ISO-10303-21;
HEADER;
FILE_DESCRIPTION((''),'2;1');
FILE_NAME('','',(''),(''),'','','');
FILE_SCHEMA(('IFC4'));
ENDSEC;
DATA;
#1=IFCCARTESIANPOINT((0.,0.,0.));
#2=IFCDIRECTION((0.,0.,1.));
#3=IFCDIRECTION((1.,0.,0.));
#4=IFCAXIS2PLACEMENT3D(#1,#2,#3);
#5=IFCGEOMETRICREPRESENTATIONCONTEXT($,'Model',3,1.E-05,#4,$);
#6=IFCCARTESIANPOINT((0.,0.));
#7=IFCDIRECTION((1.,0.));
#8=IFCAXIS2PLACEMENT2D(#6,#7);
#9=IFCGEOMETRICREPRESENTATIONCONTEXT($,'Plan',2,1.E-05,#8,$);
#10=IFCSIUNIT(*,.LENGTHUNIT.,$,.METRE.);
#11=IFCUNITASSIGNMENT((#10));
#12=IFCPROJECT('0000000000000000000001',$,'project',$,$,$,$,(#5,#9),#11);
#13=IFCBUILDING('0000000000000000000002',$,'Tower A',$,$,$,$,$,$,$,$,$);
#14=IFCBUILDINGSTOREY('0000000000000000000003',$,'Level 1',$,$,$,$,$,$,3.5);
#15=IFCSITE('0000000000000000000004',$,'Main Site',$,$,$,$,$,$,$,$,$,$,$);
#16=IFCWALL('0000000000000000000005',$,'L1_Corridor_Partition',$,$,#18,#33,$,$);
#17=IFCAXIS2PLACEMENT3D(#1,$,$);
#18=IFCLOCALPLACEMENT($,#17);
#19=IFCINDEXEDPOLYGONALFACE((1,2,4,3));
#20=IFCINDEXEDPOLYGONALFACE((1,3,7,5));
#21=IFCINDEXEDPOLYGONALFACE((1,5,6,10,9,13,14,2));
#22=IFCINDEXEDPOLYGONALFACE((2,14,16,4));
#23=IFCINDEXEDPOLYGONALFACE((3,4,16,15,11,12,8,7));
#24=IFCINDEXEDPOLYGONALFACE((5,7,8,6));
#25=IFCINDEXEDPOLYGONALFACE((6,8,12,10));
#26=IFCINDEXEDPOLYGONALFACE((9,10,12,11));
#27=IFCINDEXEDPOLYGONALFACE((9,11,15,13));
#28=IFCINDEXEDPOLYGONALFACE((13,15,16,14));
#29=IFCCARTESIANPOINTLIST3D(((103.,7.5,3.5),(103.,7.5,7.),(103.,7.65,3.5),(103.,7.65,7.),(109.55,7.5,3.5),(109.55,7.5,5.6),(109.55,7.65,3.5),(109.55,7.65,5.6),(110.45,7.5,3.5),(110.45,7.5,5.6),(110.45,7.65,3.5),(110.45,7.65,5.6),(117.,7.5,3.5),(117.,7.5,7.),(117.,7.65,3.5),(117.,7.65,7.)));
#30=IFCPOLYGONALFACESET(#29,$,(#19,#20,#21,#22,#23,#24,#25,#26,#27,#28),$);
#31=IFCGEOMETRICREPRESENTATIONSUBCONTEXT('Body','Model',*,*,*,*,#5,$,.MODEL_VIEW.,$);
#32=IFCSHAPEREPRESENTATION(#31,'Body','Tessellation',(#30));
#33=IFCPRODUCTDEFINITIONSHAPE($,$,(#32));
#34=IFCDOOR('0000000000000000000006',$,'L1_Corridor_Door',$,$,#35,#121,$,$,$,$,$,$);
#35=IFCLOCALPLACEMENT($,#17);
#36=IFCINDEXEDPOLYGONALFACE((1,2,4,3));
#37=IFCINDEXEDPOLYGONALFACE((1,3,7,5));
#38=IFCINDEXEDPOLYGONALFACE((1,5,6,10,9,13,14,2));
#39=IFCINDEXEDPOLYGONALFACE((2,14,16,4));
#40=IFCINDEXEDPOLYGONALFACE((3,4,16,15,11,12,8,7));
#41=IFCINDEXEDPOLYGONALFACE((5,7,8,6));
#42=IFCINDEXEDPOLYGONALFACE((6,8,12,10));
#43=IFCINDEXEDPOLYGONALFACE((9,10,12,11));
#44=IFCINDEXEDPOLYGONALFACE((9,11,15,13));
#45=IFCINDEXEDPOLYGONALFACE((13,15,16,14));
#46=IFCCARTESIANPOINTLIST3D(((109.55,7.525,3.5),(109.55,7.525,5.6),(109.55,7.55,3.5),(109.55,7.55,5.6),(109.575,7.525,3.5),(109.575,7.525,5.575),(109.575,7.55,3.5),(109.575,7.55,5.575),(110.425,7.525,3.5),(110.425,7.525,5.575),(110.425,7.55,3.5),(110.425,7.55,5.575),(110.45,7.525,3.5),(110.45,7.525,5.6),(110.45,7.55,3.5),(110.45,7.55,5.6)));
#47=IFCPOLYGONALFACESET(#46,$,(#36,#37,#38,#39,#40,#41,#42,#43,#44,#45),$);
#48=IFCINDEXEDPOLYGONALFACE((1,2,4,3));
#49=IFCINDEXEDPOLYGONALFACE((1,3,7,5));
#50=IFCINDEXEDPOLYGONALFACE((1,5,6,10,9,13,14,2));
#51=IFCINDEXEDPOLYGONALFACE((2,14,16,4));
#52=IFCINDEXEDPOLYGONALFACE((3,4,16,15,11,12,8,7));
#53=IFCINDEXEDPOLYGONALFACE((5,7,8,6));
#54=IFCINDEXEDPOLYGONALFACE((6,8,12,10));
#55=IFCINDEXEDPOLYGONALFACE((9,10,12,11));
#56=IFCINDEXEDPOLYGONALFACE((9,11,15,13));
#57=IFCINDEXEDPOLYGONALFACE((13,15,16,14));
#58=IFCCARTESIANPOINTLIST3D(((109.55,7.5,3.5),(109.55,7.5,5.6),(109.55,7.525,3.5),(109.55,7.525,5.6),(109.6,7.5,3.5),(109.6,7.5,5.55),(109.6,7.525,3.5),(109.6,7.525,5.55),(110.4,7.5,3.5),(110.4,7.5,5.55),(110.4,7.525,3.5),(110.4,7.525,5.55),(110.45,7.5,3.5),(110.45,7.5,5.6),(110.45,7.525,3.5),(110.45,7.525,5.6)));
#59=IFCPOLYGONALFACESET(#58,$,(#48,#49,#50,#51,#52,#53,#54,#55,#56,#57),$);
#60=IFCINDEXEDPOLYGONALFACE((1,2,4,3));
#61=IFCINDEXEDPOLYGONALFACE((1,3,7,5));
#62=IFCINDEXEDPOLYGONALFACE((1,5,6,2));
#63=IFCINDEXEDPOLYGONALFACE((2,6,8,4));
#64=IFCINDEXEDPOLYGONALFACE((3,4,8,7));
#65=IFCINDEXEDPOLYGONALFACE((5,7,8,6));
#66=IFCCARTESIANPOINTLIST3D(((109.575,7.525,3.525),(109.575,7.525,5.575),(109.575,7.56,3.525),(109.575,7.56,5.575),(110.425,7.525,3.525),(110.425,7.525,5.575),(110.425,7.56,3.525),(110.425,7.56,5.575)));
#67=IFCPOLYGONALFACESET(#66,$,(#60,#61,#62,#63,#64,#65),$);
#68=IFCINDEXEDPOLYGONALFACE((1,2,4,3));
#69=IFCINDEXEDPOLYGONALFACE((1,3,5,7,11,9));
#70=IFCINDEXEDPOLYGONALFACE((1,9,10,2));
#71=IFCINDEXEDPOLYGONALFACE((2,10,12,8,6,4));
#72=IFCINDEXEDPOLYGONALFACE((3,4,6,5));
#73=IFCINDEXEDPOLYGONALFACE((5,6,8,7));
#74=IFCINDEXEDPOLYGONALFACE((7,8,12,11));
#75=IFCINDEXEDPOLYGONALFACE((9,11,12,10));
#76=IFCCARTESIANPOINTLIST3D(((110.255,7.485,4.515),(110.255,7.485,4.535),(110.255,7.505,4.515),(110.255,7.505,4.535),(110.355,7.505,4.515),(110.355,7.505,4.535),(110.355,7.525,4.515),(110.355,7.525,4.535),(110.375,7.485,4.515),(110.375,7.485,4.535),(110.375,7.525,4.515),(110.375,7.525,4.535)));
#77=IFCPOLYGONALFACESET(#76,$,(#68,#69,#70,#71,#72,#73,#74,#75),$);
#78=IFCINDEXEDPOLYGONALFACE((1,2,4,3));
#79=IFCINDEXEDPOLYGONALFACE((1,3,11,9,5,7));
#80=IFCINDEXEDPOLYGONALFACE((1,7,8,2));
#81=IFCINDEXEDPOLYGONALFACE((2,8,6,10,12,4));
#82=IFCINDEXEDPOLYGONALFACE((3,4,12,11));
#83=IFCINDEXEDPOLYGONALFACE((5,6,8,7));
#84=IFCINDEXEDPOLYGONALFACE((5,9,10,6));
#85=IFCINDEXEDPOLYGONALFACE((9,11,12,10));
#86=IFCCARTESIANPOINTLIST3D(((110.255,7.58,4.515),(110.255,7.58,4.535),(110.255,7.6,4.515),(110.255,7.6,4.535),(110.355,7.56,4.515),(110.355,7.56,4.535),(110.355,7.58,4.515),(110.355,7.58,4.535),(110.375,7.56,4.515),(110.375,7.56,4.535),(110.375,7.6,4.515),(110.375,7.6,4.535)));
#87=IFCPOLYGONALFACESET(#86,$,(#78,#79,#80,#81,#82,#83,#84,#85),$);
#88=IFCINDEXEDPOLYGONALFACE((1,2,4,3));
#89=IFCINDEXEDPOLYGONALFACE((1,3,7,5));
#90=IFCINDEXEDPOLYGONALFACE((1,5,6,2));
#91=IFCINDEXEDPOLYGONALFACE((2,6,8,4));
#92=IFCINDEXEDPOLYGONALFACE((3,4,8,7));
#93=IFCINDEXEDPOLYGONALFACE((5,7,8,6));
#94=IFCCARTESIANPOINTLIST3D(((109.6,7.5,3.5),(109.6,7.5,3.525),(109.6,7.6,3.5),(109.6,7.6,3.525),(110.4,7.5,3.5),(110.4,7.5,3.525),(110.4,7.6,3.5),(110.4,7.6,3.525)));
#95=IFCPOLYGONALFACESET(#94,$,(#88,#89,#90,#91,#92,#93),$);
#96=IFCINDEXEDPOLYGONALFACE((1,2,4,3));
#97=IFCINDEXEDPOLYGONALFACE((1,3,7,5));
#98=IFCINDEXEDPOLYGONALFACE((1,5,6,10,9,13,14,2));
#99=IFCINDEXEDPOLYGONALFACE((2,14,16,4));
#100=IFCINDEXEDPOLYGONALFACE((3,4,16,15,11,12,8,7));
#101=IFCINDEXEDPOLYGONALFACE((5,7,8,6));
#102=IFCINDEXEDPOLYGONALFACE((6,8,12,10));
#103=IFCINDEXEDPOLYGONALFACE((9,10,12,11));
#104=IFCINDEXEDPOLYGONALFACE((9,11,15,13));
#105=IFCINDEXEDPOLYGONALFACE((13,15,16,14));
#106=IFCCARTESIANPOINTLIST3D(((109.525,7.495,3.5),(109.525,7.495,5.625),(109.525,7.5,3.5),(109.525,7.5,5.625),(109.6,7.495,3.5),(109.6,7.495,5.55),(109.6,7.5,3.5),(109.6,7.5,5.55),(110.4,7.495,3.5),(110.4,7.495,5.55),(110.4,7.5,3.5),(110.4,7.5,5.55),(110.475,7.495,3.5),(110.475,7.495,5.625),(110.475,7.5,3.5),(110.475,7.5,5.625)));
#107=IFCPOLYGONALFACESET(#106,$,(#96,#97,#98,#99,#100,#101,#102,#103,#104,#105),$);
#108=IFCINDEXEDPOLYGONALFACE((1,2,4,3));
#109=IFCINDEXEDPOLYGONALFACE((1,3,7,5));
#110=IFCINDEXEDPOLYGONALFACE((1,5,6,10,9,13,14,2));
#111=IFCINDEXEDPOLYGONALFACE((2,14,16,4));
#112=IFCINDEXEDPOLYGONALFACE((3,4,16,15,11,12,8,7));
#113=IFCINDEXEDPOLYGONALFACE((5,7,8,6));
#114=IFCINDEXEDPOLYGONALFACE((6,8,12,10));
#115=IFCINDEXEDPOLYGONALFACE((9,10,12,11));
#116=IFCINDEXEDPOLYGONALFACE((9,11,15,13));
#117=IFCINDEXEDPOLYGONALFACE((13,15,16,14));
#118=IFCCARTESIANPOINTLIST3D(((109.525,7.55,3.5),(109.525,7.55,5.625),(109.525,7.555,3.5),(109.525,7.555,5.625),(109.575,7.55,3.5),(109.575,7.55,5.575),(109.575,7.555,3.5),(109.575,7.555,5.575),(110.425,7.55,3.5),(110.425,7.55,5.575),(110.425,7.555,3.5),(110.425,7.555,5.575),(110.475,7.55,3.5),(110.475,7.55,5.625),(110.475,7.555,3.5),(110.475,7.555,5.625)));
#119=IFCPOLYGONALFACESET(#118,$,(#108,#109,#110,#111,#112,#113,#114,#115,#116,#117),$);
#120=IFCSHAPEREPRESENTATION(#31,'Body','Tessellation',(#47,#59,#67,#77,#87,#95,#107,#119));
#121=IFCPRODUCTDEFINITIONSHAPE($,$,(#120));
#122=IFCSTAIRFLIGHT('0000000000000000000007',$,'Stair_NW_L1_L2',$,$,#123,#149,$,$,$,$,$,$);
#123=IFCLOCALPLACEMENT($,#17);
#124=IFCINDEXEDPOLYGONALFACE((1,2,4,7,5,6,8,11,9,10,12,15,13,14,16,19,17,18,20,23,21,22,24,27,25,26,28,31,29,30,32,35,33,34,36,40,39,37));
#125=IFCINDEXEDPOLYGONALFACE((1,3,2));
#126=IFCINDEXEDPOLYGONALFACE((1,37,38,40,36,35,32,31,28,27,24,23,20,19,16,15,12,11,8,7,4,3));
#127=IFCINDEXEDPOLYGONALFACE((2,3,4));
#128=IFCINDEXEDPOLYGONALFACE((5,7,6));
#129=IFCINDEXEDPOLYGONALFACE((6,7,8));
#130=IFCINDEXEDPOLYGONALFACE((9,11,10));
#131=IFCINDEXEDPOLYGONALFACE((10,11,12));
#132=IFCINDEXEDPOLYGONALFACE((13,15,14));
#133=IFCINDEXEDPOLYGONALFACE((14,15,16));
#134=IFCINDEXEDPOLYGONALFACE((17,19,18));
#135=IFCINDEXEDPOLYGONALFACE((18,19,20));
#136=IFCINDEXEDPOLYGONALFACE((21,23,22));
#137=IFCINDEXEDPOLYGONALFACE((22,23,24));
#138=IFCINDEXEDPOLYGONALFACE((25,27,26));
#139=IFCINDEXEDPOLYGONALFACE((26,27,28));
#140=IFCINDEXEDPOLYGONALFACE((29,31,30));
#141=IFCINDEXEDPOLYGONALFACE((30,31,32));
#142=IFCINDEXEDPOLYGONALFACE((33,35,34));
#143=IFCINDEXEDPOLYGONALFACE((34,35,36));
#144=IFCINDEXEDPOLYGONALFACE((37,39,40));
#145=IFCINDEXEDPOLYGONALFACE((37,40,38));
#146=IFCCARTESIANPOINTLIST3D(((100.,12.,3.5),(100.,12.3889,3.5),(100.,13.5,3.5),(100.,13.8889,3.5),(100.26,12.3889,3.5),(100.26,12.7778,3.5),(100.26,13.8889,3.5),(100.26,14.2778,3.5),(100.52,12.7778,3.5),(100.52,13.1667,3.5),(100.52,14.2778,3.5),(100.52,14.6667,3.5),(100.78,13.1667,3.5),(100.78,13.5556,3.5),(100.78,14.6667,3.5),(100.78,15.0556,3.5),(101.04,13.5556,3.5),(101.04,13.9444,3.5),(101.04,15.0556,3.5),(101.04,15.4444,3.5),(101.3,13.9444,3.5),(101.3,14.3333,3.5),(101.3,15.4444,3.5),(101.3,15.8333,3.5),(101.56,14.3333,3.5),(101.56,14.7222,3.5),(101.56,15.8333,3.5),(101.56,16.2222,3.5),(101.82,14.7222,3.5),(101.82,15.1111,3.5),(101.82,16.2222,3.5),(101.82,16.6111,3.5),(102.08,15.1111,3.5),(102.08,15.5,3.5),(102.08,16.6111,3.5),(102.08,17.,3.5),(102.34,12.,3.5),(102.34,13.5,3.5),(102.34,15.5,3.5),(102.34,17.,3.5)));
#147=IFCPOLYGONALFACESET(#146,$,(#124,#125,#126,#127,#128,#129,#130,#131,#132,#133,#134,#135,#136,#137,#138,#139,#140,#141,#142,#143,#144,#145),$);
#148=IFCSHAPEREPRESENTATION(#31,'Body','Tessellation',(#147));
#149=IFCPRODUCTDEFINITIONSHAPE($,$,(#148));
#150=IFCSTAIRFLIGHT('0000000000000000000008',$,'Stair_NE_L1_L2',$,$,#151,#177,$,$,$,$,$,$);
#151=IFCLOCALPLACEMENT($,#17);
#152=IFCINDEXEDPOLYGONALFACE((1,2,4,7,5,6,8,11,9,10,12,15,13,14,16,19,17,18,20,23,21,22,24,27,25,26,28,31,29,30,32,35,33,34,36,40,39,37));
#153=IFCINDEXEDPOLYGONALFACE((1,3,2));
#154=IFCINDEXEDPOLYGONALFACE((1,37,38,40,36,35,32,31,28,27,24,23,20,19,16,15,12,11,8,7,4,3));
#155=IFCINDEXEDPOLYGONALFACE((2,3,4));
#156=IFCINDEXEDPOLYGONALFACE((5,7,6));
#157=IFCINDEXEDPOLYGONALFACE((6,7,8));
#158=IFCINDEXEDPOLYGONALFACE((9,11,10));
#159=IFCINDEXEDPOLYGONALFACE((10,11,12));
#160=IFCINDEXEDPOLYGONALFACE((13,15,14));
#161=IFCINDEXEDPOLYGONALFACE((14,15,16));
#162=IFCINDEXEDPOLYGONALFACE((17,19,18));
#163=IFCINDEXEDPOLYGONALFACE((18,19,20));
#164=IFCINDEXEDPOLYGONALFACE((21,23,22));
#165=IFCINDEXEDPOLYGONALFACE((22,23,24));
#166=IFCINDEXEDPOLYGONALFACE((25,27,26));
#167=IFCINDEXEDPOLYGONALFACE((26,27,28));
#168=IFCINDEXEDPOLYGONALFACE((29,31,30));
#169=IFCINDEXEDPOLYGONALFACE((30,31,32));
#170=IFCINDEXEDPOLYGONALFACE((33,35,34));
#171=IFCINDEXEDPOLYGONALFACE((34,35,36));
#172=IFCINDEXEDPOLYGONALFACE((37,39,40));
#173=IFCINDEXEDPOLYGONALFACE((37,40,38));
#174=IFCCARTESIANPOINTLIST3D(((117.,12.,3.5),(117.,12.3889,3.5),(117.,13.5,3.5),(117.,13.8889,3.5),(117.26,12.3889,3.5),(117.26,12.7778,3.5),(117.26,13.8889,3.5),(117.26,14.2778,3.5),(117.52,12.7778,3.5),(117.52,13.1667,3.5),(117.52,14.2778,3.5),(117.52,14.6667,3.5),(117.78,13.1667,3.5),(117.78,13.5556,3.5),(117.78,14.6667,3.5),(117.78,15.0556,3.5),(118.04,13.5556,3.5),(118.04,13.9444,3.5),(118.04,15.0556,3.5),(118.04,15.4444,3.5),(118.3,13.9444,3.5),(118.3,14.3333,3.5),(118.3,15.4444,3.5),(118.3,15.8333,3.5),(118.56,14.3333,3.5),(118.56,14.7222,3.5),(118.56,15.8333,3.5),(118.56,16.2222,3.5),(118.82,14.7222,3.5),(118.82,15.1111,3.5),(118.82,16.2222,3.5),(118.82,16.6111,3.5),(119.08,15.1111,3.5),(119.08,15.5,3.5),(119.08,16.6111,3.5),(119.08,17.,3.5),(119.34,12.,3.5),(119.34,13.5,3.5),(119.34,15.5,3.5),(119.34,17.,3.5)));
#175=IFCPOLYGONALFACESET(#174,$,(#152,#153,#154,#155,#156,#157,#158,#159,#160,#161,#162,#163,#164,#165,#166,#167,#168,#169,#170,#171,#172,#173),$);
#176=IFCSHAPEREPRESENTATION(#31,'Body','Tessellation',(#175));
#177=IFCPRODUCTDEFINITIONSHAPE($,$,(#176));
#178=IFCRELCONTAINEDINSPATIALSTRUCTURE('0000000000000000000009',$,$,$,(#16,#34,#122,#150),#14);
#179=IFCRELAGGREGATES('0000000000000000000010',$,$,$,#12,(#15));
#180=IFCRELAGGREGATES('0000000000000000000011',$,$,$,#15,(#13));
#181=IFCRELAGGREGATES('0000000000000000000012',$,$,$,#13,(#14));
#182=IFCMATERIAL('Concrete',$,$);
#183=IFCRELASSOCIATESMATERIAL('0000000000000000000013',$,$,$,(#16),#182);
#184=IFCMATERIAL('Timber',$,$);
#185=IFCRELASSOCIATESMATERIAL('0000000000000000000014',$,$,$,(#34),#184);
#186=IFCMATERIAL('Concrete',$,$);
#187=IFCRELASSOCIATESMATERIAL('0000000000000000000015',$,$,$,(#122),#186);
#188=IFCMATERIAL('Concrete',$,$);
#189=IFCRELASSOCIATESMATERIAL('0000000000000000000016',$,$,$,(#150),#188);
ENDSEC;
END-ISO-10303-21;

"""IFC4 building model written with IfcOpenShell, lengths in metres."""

from ifc_helpers import new_model, si_unit, frame, origin_with_axes, origin_2d_with_axis, place, context, subcontext, project, spatial, line, indexed_curve, outline, extrude, material, element, fill, save


model = new_model("IFC4")

# Units and contexts
model_context = context("Model", 3, precision=1e-05, world=origin_with_axes())
plan_context = context("Plan", 2, precision=1e-05, world=origin_2d_with_axis())
body_context = subcontext(model_context, "Body", "Model", "MODEL_VIEW")
ifc_project = project(units=[si_unit("LENGTHUNIT", "METRE")], contexts=[model_context, plan_context])

# Site, building, storey
site = spatial("IfcSite", under=ifc_project, Name="Main Site")
building = spatial("IfcBuilding", under=site, Name="Tower A")
storey = spatial("IfcBuildingStorey", under=building, Name="Level 1", Elevation=3.5)

# Wall, opening, door
ifc_material_1 = material(Name="Concrete")
wall_1_placement = place(None, frame((103.0, 7.5, 3.5), z_axis=(0.0, 0.0, 1.0), x_axis=(1.0, 0.0, 0.0)))
wall_1 = element("IfcWall", 1, at=wall_1_placement, inside=storey, material=ifc_material_1, Name="L1_Corridor_Partition", context=body_context, shape_type="SweptSolid", body=[
    extrude(outline(indexed_curve([(0.0, 0.0), (0.0, 0.15), (14.0, 0.15), (14.0, 0.0), (0.0, 0.0)], self_intersect=False)), origin_with_axes(), (0.0, 0.0, 1.0), 3.5),
])
opening_1_placement = place(wall_1_placement, frame((6.55, 0.0, 0.0), z_axis=(0.0, 0.0, 1.0), x_axis=(1.0, 0.0, 0.0)))
opening_1 = element("IfcOpeningElement", 2, at=opening_1_placement, cuts=wall_1, context=body_context, shape_type="SweptSolid", body=[
    extrude(outline(indexed_curve([(0.0, 0.0), (0.0, 0.2), (0.9, 0.2), (0.9, 0.0), (0.0, 0.0)], self_intersect=False)), origin_with_axes(), (0.0, 0.0, 1.0), 2.1),
])
ifc_material_2 = material(Name="Timber")
door_placement = place(None, frame((109.55, 7.5, 3.5), z_axis=(0.0, 0.0, 1.0), x_axis=(1.0, 0.0, 0.0)))
door = element("IfcDoor", 3, at=door_placement, inside=storey, material=ifc_material_2, Name="L1_Corridor_Door", context=body_context, shape_type="SweptSolid", body=[
    extrude(outline(indexed_curve([(0.0, 0.0), (0.0, 2.1), (0.9, 2.1), (0.9, 0.0), (0.875, 0.0), (0.875, 2.075), (0.025, 2.075), (0.025, 0.0)], segments=[line(1, 2, 3, 4, 5, 6, 7, 8, 1)])), frame((0.0, 0.025, 0.0), z_axis=(0.0, -1.0, 0.0), x_axis=(1.0, 0.0, 0.0)), (0.0, 0.0, -1.0), 0.025),
    extrude(outline(indexed_curve([(0.0, 0.0), (0.0, 2.1), (0.9, 2.1), (0.9, 0.0), (0.85, 0.0), (0.85, 2.05), (0.05, 2.05), (0.05, 0.0)], segments=[line(1, 2, 3, 4, 5, 6, 7, 8, 1)])), frame((0.0, 0.0, 0.0), z_axis=(0.0, -1.0, 0.0), x_axis=(1.0, 0.0, 0.0)), (0.0, 0.0, -1.0), 0.025),
    extrude(outline(indexed_curve([(0.0, 0.0), (0.85, 0.0), (0.85, 0.035), (0.0, 0.035)], segments=[line(1, 2, 3, 4, 1)])), frame((0.025, 0.025, 0.025), z_axis=(0.0, 0.0, 1.0), x_axis=(1.0, 0.0, 0.0)), (0.0, 0.0, 1.0), 2.05),
    extrude(outline(indexed_curve([(0.0, 0.0), (0.0, -0.04), (-0.12, -0.04), (-0.12, -0.02), (-0.02, -0.02), (-0.02, 0.0)], segments=[line(1, 2, 3, 4, 5, 6, 1)])), frame((0.825, 0.025, 1.015), z_axis=(0.0, 0.0, 1.0), x_axis=(1.0, 0.0, 0.0)), (0.0, 0.0, 1.0), 0.02),
    extrude(outline(indexed_curve([(0.0, 0.0), (0.0, 0.04), (-0.12, 0.04), (-0.12, 0.02), (-0.02, 0.02), (-0.02, 0.0)], segments=[line(1, 2, 3, 4, 5, 6, 1)])), frame((0.825, 0.06, 1.015), z_axis=(0.0, 0.0, 1.0), x_axis=(1.0, 0.0, 0.0)), (0.0, 0.0, 1.0), 0.02),
    extrude(outline(indexed_curve([(0.0, 0.0), (0.8, 0.0), (0.8, 0.1), (0.0, 0.1)], segments=[line(1, 2, 3, 4, 1)])), frame((0.05, 0.0, 0.0), z_axis=(0.0, 0.0, 1.0), x_axis=(1.0, 0.0, 0.0)), (0.0, 0.0, 1.0), 0.025),
    extrude(outline(indexed_curve([(0.0, 0.0), (0.0, 2.125), (0.95, 2.125), (0.95, 0.0), (0.875, 0.0), (0.875, 2.05), (0.075, 2.05), (0.075, 0.0)], segments=[line(1, 2, 3, 4, 5, 6, 7, 8, 1)])), frame((-0.025, -0.005, 0.0), z_axis=(0.0, -1.0, 0.0), x_axis=(1.0, 0.0, 0.0)), (0.0, 0.0, -1.0), 0.005),
    extrude(outline(indexed_curve([(0.0, 0.0), (0.0, 2.125), (0.95, 2.125), (0.95, 0.0), (0.9, 0.0), (0.9, 2.075), (0.05, 2.075), (0.05, 0.0)], segments=[line(1, 2, 3, 4, 5, 6, 7, 8, 1)])), frame((-0.025, 0.05, 0.0), z_axis=(0.0, -1.0, 0.0), x_axis=(1.0, 0.0, 0.0)), (0.0, 0.0, -1.0), 0.005),
])
fill(opening_1, door)

# Stair flights
ifc_material_3 = material(Name="Concrete")
stair_flight_1_placement = place(None, frame((100.0, 12.0, 3.5), z_axis=(0.0, 0.0, 1.0), x_axis=(1.0, 0.0, 0.0)))
element("IfcStairFlight", 4, at=stair_flight_1_placement, inside=storey, material=ifc_material_3, Name="Stair_NW_L1_L2", context=body_context, shape_type="SweptSolid", body=[
    extrude(outline(indexed_curve([(0.0, 0.0), (0.0, 0.3889), (0.26, 0.3889), (0.26, 0.7778), (0.52, 0.7778), (0.52, 1.1667), (0.78, 1.1667), (0.78, 1.5556), (1.04, 1.5556), (1.04, 1.9444), (1.3, 1.9444), (1.3, 2.3333), (1.56, 2.3333), (1.56, 2.7222), (1.82, 2.7222), (1.82, 3.1111), (2.08, 3.1111), (2.08, 3.5), (2.34, 3.5), (2.34, 0.0)], segments=[line(1, 2, 3, 4, 5, 6, 7, 8, 9, 10, 11, 12, 13, 14, 15, 16, 17, 18, 19, 20, 1)])), origin_with_axes(), (0.0, 1.0, 0.0), 1.5),
])
ifc_material_4 = material(Name="Concrete")
stair_flight_2_placement = place(None, frame((117.0, 12.0, 3.5), z_axis=(0.0, 0.0, 1.0), x_axis=(1.0, 0.0, 0.0)))
element("IfcStairFlight", 5, at=stair_flight_2_placement, inside=storey, material=ifc_material_4, Name="Stair_NE_L1_L2", context=body_context, shape_type="SweptSolid", body=[
    extrude(outline(indexed_curve([(0.0, 0.0), (0.0, 0.3889), (0.26, 0.3889), (0.26, 0.7778), (0.52, 0.7778), (0.52, 1.1667), (0.78, 1.1667), (0.78, 1.5556), (1.04, 1.5556), (1.04, 1.9444), (1.3, 1.9444), (1.3, 2.3333), (1.56, 2.3333), (1.56, 2.7222), (1.82, 2.7222), (1.82, 3.1111), (2.08, 3.1111), (2.08, 3.5), (2.34, 3.5), (2.34, 0.0)], segments=[line(1, 2, 3, 4, 5, 6, 7, 8, 9, 10, 11, 12, 13, 14, 15, 16, 17, 18, 19, 20, 1)])), origin_with_axes(), (0.0, 1.0, 0.0), 1.5),
])

save(model, "model.ifc")
